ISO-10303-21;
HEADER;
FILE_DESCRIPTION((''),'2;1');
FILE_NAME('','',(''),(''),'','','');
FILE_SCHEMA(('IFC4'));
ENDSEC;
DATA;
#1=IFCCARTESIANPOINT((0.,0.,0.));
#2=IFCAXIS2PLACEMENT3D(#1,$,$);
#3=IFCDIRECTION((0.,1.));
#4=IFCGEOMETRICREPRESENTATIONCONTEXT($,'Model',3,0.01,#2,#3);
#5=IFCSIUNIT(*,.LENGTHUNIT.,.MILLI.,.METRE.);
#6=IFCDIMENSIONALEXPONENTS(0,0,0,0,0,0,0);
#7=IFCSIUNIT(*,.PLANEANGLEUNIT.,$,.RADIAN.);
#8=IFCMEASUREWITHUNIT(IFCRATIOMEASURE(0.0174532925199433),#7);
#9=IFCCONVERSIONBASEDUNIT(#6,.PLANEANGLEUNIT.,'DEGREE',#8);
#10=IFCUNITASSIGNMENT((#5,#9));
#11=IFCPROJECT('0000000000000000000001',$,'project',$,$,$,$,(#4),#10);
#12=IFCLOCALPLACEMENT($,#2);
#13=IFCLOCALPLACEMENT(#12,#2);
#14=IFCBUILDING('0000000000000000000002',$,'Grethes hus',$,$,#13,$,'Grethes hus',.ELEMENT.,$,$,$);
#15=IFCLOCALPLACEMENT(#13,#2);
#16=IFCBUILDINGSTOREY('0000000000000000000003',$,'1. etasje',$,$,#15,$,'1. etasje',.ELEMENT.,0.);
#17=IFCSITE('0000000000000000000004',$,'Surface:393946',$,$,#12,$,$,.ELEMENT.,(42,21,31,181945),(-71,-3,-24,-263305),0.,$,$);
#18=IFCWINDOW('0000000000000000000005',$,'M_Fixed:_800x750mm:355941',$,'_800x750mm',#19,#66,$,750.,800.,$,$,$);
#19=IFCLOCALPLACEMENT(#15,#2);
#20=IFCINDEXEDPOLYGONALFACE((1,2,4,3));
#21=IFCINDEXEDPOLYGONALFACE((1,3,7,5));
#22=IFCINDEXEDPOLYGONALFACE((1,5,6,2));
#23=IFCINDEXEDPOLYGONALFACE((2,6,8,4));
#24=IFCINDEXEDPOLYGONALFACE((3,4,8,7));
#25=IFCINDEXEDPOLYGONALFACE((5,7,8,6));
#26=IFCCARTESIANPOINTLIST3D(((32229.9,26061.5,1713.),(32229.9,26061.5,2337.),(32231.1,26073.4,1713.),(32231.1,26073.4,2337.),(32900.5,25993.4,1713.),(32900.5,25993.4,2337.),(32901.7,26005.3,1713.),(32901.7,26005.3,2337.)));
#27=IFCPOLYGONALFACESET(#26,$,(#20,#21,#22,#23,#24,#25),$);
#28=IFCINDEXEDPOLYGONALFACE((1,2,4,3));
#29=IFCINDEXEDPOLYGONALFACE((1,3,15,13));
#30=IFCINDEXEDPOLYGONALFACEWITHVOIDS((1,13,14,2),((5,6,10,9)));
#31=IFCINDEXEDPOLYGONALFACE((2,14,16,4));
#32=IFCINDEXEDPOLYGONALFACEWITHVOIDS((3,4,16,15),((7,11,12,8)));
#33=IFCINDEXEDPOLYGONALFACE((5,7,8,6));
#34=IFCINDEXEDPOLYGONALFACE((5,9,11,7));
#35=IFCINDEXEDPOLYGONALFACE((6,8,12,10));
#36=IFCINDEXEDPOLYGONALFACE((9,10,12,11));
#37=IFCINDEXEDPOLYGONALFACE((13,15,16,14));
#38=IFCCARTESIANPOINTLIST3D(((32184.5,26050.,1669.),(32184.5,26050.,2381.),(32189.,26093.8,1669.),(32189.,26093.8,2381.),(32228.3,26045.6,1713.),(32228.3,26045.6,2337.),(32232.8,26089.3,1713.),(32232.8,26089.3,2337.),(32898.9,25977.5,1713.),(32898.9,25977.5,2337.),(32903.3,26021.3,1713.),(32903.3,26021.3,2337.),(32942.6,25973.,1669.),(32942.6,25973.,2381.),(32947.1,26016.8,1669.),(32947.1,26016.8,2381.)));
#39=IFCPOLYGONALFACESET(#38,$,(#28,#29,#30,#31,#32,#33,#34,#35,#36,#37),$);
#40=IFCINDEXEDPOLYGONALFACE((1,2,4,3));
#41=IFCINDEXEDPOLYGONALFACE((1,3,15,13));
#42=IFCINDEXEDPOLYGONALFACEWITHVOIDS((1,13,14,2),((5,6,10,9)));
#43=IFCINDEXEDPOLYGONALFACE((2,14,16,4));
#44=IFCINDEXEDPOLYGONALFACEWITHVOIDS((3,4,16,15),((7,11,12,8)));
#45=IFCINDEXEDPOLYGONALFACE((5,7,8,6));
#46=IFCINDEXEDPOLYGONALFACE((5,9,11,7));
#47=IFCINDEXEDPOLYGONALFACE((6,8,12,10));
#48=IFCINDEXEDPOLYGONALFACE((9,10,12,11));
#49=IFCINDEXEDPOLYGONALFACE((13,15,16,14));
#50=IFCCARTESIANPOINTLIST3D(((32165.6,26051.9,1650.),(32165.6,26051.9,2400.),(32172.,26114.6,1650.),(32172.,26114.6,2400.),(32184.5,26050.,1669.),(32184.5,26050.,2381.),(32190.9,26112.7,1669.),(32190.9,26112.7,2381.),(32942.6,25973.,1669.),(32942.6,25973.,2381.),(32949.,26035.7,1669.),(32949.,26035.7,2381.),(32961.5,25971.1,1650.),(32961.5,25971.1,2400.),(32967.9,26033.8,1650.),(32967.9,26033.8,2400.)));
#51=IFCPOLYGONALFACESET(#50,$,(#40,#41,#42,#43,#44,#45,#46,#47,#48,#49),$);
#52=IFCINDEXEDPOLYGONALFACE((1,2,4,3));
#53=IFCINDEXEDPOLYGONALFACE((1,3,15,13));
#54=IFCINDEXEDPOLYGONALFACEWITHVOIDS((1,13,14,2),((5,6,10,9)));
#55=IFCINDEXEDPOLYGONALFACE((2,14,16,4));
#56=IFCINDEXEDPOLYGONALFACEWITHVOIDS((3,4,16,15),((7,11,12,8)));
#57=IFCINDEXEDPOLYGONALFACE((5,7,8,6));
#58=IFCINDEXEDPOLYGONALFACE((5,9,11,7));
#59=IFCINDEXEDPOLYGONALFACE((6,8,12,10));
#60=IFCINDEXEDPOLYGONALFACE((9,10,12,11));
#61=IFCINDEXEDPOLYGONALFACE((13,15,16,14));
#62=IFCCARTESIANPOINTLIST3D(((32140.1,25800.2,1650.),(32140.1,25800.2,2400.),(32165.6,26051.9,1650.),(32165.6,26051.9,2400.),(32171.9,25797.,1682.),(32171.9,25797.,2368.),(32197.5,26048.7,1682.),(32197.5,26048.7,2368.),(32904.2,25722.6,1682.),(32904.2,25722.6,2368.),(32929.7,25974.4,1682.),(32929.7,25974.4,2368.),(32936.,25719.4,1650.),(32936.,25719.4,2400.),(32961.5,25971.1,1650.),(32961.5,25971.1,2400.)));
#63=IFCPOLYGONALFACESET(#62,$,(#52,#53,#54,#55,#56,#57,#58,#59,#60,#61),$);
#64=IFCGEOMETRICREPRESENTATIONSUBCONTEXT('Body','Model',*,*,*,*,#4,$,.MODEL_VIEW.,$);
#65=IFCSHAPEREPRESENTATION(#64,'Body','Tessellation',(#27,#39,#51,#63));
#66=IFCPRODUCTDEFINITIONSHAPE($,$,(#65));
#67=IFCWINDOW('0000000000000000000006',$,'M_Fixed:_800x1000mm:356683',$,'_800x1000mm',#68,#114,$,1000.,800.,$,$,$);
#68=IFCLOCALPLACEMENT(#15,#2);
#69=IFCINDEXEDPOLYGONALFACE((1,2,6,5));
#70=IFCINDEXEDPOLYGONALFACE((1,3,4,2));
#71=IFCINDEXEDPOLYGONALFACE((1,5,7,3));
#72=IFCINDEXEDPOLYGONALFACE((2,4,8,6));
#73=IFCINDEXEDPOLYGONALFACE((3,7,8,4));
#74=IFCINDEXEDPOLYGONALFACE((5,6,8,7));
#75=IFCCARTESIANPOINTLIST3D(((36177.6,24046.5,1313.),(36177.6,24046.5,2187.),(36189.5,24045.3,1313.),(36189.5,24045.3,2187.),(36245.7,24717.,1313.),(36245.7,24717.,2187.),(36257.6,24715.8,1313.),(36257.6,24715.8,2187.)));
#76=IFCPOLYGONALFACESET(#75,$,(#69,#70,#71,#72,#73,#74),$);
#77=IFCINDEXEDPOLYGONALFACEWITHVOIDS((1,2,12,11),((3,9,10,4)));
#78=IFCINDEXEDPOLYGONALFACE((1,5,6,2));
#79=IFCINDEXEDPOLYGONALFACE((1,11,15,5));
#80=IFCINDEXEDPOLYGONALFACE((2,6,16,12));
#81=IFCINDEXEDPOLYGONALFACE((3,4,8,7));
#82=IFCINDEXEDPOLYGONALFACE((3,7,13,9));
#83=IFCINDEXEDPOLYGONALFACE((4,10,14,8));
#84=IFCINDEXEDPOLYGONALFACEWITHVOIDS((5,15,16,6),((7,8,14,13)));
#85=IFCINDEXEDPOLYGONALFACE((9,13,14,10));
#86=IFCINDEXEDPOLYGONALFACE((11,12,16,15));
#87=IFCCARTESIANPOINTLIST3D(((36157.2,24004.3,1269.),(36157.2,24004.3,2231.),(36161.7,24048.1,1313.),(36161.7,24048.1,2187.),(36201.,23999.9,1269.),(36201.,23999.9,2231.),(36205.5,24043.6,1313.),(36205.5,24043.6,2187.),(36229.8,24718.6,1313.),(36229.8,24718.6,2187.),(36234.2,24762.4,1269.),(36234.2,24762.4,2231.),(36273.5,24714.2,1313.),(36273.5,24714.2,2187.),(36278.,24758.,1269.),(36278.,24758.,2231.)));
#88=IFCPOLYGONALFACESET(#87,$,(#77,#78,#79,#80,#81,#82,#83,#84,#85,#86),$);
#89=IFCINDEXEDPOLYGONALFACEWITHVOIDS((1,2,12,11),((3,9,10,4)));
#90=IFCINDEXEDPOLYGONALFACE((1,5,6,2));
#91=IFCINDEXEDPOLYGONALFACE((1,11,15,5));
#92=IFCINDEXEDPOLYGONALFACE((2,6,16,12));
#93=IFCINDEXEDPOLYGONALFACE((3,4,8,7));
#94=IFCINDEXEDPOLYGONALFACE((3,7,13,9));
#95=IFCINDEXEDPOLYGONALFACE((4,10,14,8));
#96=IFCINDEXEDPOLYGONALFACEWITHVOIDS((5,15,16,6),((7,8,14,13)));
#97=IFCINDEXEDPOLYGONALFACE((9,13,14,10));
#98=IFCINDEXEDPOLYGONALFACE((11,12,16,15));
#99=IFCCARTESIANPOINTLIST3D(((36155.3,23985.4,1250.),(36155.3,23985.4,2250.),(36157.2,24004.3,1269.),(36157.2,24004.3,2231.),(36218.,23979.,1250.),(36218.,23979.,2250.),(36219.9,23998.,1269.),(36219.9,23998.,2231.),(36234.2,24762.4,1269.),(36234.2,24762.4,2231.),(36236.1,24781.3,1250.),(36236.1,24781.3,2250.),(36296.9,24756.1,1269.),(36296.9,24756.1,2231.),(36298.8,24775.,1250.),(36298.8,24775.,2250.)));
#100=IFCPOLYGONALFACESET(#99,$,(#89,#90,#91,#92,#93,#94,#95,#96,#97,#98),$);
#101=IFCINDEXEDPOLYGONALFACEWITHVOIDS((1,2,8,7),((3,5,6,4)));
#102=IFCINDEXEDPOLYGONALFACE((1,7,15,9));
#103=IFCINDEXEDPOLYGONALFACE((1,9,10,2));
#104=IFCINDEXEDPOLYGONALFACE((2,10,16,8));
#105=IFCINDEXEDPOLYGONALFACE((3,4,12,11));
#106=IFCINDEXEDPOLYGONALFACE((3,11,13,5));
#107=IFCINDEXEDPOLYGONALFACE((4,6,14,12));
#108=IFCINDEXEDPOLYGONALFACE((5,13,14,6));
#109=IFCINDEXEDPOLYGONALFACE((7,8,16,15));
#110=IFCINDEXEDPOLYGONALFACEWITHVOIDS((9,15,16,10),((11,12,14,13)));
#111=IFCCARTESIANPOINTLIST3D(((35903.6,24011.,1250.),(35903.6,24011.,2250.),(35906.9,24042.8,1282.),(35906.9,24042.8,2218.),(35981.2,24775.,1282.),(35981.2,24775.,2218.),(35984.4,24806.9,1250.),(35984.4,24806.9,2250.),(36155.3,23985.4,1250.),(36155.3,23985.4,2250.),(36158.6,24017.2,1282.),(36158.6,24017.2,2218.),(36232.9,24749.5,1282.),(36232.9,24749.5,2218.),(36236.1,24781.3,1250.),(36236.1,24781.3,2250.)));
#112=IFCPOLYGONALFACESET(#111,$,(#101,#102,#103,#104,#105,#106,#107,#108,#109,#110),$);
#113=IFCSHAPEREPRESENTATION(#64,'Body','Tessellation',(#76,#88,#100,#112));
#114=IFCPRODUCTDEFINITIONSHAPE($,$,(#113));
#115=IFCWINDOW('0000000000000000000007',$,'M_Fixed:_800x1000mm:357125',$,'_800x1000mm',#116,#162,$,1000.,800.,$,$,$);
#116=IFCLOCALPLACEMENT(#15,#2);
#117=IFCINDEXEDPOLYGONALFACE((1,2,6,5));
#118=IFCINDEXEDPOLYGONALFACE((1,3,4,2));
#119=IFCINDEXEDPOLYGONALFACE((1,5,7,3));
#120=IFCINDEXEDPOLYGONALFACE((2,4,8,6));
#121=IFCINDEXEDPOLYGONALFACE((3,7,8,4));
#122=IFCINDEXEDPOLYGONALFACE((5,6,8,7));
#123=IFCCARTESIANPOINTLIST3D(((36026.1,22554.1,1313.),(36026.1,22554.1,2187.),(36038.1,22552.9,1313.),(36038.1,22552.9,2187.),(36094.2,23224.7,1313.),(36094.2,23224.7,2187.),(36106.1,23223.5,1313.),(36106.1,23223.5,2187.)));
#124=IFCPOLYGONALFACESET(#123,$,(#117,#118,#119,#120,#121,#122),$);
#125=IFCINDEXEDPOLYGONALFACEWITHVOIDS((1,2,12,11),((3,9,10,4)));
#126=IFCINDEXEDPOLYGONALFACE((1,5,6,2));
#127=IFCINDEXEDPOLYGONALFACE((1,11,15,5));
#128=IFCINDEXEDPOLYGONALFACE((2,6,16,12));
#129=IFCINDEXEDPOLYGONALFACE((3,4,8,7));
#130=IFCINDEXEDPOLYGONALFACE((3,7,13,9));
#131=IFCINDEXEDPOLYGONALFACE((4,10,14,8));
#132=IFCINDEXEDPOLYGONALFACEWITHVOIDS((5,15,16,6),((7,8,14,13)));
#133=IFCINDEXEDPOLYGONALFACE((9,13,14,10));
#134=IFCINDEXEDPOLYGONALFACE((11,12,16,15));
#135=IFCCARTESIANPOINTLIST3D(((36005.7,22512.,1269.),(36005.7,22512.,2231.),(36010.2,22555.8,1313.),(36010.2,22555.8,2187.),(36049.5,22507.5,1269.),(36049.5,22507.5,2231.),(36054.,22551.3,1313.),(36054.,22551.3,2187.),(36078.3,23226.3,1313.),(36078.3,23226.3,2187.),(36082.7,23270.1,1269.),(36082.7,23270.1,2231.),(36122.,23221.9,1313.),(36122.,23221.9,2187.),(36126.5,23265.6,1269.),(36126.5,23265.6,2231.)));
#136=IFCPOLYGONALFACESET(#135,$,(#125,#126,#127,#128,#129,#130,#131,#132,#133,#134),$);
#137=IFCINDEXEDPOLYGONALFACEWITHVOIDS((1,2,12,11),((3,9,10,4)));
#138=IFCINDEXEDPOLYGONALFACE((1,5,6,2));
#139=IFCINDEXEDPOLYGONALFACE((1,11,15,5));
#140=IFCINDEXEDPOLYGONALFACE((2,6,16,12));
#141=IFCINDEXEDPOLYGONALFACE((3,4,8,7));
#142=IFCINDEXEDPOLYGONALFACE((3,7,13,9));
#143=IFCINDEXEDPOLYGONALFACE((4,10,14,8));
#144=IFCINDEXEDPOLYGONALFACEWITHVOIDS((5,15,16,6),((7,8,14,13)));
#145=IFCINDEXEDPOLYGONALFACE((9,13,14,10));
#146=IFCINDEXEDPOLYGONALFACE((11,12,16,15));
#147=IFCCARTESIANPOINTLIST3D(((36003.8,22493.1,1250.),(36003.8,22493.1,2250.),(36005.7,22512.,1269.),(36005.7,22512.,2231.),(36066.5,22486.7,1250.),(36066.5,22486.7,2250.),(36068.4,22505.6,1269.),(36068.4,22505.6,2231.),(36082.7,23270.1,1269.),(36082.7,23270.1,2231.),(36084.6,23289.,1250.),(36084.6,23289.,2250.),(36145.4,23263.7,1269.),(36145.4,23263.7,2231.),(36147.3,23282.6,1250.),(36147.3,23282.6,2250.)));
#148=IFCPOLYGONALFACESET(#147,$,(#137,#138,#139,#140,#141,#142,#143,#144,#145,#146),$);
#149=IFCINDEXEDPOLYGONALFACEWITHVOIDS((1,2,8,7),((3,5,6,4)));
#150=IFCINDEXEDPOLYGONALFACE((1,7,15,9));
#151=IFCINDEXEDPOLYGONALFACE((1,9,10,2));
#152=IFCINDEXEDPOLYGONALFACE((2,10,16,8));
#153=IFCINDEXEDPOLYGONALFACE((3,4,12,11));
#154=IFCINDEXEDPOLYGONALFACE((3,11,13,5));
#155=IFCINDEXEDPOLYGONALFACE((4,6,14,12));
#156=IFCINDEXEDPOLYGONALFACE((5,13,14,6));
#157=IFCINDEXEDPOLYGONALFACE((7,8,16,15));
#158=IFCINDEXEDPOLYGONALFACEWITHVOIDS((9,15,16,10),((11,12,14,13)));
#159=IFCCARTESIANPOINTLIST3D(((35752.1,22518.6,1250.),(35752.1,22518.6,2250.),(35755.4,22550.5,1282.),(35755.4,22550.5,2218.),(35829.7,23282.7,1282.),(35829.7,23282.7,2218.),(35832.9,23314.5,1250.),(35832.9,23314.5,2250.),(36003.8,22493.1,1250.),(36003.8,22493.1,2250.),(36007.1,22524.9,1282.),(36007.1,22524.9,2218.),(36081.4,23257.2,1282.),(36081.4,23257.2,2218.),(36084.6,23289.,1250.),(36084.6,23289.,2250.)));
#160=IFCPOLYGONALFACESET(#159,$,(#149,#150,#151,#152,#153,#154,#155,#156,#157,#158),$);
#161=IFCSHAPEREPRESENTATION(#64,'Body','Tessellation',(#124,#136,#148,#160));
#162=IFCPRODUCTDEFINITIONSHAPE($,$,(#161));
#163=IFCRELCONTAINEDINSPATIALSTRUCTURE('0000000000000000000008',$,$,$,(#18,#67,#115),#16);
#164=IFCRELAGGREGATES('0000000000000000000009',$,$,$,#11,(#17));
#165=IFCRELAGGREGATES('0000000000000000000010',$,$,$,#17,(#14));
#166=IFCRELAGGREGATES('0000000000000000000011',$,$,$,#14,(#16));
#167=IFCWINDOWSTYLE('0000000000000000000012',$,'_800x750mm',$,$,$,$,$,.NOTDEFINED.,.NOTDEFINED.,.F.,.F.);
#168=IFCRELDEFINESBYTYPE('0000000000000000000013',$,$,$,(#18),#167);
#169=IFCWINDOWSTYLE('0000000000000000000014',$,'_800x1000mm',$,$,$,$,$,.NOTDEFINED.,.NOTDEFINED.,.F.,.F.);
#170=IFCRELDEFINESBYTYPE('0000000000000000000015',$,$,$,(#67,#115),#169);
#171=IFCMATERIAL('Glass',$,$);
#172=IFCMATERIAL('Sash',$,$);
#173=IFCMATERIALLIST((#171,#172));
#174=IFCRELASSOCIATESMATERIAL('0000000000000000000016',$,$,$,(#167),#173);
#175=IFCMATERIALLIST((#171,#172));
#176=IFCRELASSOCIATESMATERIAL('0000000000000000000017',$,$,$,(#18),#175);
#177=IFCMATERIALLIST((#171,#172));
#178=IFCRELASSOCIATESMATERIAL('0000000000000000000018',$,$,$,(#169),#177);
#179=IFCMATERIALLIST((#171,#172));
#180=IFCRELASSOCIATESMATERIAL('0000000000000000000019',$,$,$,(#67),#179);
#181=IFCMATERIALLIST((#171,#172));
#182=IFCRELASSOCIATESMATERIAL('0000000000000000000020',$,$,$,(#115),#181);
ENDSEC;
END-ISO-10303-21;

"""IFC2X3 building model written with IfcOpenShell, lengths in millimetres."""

from ifc_helpers import new_model, entity, si_unit, converted_unit, direction, frame, frame_2d, origin, place, context, subcontext, project, spatial, polyline, rectangle, outline, extrude, source, transform, mapped, material, material_list, type_object, type_shapes, element, save


model = new_model("IFC2X3")

# Units and contexts
model_context = context("Model", 3, precision=0.01, world=origin(), true_north=direction((0.0, 1.0)))
body_context = subcontext(model_context, "Body", "Model", "MODEL_VIEW")
ifc_project = project(units=[si_unit("LENGTHUNIT", "METRE", prefix="MILLI"), converted_unit("PLANEANGLEUNIT", "DEGREE", entity("IfcRatioMeasure", 0.0174532925199433), si_unit("PLANEANGLEUNIT", "RADIAN"), dimensions=[0, 0, 0, 0, 0, 0, 0])], contexts=[model_context])

# Site, building, storey
site_placement = place(None, origin())
site = spatial("IfcSite", under=ifc_project, at=site_placement, Name="Surface:393946", CompositionType="ELEMENT", RefLatitude=(42, 21, 31, 181945), RefLongitude=(-71, -3, -24, -263305), RefElevation=0.0)
building_placement = place(site_placement, origin())
building = spatial("IfcBuilding", under=site, at=building_placement, Name="Grethes hus", LongName="Grethes hus", CompositionType="ELEMENT")
storey_placement = place(building_placement, origin())
storey = spatial("IfcBuildingStorey", under=building, at=storey_placement, Name="1. etasje", LongName="1. etasje", CompositionType="ELEMENT", Elevation=0.0)

# Windows
ifc_material_1 = material(Name="Glass")
ifc_material_2 = material(Name="Sash")
ifc_material_list_1 = material_list([ifc_material_1, ifc_material_2])
ifc_material_list_2 = material_list([ifc_material_1, ifc_material_2])
window_style_1 = type_object("IfcWindowStyle", Name="_800x750mm", ConstructionType="NOTDEFINED", OperationType="NOTDEFINED", ParameterTakesPrecedence=False, Sizeable=False, material=ifc_material_list_2)
shared_shape_1 = source(origin(), body_context, "Body", "SweptSolid", [
    extrude(rectangle(XDim=674.0, YDim=12.0, at=frame_2d((0.0, 0.0), x_axis=(1.0, 0.0))), frame((400.0, 301.0, 63.0), z_axis=(0.0, 0.0, 1.0), x_axis=(-1.0, 0.0, 0.0)), (0.0, 0.0, 1.0), 624.0),
    extrude(outline(polyline([(-381.0, -356.0), (381.0, -356.0), (381.0, 356.0), (-381.0, 356.0), (-381.0, -356.0)]), holes=[polyline([(-337.0, -312.0), (-337.0, 312.0), (337.0, 312.0), (337.0, -312.0), (-337.0, -312.0)])]), frame((400.0, 323.0, 375.0), z_axis=(0.0, -1.0, 0.0), x_axis=(-1.0, 0.0, 0.0)), (0.0, 0.0, 1.0), 44.0),
    extrude(outline(polyline([(-400.0, -375.0), (400.0, -375.0), (400.0, 375.0), (-400.0, 375.0), (-400.0, -375.0)]), holes=[polyline([(-381.0, -356.0), (-381.0, 356.0), (381.0, 356.0), (381.0, -356.0), (-381.0, -356.0)])]), frame((400.0, 342.0, 375.0), z_axis=(0.0, -1.0, 0.0), x_axis=(-1.0, 0.0, 0.0)), (0.0, 0.0, 1.0), 63.0),
    extrude(outline(polyline([(-400.0, -375.0), (400.0, -375.0), (400.0, 375.0), (-400.0, 375.0), (-400.0, -375.0)]), holes=[polyline([(-368.0, -343.0), (-368.0, 343.0), (368.0, 343.0), (368.0, -343.0), (-368.0, -343.0)])]), frame((400.0, 279.0, 375.0), z_axis=(0.0, -1.0, 0.0), x_axis=(-1.0, 0.0, 0.0)), (0.0, 0.0, 1.0), 253.0),
])
type_shapes(window_style_1, [shared_shape_1])
placement_1 = place(storey_placement, frame((17757.0, 27419.1, 400.0), z_axis=(0.0, 0.0, 1.0), x_axis=(0.994887, -0.100996, 0.0)))
placement_2 = place(placement_1, frame((14473.0, -158.0, 1250.0)))
window_1_placement = place(placement_2, frame((0.0, -26.0, 0.0)))
element("IfcWindow", 1, at=window_1_placement, inside=storey, type_object=window_style_1, material=ifc_material_list_1, Name="M_Fixed:_800x750mm:355941", ObjectType="_800x750mm", OverallHeight=750.0, OverallWidth=800.0, context=body_context, shape_type="MappedRepresentation", body=[
    mapped(shared_shape_1, transform((0.0, 0.0, 0.0), scale=1.0)),
])
ifc_material_list_3 = material_list([ifc_material_1, ifc_material_2])
ifc_material_list_4 = material_list([ifc_material_1, ifc_material_2])
window_style_2 = type_object("IfcWindowStyle", Name="_800x1000mm", ConstructionType="NOTDEFINED", OperationType="NOTDEFINED", ParameterTakesPrecedence=False, Sizeable=False, material=ifc_material_list_4)
shared_shape_2 = source(origin(), body_context, "Body", "SweptSolid", [
    extrude(rectangle(XDim=12.0, YDim=674.0, at=frame_2d((0.0, 0.0), x_axis=(1.0, 0.0))), frame((400.0, 275.0, 63.0), z_axis=(0.0, 0.0, 1.0), x_axis=(0.0, -1.0, 0.0)), (0.0, 0.0, 1.0), 874.0),
    extrude(outline(polyline([(-381.0, -481.0), (381.0, -481.0), (381.0, 481.0), (-381.0, 481.0), (-381.0, -481.0)]), holes=[polyline([(-337.0, -437.0), (-337.0, 437.0), (337.0, 437.0), (337.0, -437.0), (-337.0, -437.0)])]), frame((400.0, 253.0, 500.0), z_axis=(0.0, 1.0, 0.0), x_axis=(1.0, 0.0, 0.0)), (0.0, 0.0, 1.0), 44.0),
    extrude(outline(polyline([(-400.0, -500.0), (400.0, -500.0), (400.0, 500.0), (-400.0, 500.0), (-400.0, -500.0)]), holes=[polyline([(-381.0, -481.0), (-381.0, 481.0), (381.0, 481.0), (381.0, -481.0), (-381.0, -481.0)])]), frame((400.0, 253.0, 500.0), z_axis=(0.0, 1.0, 0.0), x_axis=(1.0, 0.0, 0.0)), (0.0, 0.0, 1.0), 63.0),
    extrude(outline(polyline([(-400.0, -500.0), (400.0, -500.0), (400.0, 500.0), (-400.0, 500.0), (-400.0, -500.0)]), holes=[polyline([(-368.0, -468.0), (-368.0, 468.0), (368.0, 468.0), (368.0, -468.0), (-368.0, -468.0)])]), frame((400.0, 0.0, 500.0), z_axis=(0.0, 1.0, 0.0), x_axis=(1.0, 0.0, 0.0)), (0.0, 0.0, 1.0), 253.0),
])
type_shapes(window_style_2, [shared_shape_2])
placement_3 = place(storey_placement, frame((36234.1, 25702.2, 0.0), z_axis=(0.0, 0.0, 1.0), x_axis=(-0.100996, -0.994887, 0.0)))
placement_4 = place(placement_3, frame((916.0, -158.0, 1250.0)))
window_2_placement = place(placement_4, origin())
element("IfcWindow", 2, at=window_2_placement, inside=storey, type_object=window_style_2, material=ifc_material_list_3, Name="M_Fixed:_800x1000mm:356683", ObjectType="_800x1000mm", OverallHeight=1000.0, OverallWidth=800.0, context=body_context, shape_type="MappedRepresentation", body=[
    mapped(shared_shape_2, transform((0.0, 0.0, 0.0), scale=1.0)),
])
ifc_material_list_5 = material_list([ifc_material_1, ifc_material_2])
placement_5 = place(placement_3, frame((2416.0, -158.0, 1250.0)))
window_3_placement = place(placement_5, origin())
element("IfcWindow", 3, at=window_3_placement, inside=storey, type_object=window_style_2, material=ifc_material_list_5, Name="M_Fixed:_800x1000mm:357125", ObjectType="_800x1000mm", OverallHeight=1000.0, OverallWidth=800.0, context=body_context, shape_type="MappedRepresentation", body=[
    mapped(shared_shape_2, transform((0.0, 0.0, 0.0), scale=1.0)),
])

save(model, "model.ifc")
